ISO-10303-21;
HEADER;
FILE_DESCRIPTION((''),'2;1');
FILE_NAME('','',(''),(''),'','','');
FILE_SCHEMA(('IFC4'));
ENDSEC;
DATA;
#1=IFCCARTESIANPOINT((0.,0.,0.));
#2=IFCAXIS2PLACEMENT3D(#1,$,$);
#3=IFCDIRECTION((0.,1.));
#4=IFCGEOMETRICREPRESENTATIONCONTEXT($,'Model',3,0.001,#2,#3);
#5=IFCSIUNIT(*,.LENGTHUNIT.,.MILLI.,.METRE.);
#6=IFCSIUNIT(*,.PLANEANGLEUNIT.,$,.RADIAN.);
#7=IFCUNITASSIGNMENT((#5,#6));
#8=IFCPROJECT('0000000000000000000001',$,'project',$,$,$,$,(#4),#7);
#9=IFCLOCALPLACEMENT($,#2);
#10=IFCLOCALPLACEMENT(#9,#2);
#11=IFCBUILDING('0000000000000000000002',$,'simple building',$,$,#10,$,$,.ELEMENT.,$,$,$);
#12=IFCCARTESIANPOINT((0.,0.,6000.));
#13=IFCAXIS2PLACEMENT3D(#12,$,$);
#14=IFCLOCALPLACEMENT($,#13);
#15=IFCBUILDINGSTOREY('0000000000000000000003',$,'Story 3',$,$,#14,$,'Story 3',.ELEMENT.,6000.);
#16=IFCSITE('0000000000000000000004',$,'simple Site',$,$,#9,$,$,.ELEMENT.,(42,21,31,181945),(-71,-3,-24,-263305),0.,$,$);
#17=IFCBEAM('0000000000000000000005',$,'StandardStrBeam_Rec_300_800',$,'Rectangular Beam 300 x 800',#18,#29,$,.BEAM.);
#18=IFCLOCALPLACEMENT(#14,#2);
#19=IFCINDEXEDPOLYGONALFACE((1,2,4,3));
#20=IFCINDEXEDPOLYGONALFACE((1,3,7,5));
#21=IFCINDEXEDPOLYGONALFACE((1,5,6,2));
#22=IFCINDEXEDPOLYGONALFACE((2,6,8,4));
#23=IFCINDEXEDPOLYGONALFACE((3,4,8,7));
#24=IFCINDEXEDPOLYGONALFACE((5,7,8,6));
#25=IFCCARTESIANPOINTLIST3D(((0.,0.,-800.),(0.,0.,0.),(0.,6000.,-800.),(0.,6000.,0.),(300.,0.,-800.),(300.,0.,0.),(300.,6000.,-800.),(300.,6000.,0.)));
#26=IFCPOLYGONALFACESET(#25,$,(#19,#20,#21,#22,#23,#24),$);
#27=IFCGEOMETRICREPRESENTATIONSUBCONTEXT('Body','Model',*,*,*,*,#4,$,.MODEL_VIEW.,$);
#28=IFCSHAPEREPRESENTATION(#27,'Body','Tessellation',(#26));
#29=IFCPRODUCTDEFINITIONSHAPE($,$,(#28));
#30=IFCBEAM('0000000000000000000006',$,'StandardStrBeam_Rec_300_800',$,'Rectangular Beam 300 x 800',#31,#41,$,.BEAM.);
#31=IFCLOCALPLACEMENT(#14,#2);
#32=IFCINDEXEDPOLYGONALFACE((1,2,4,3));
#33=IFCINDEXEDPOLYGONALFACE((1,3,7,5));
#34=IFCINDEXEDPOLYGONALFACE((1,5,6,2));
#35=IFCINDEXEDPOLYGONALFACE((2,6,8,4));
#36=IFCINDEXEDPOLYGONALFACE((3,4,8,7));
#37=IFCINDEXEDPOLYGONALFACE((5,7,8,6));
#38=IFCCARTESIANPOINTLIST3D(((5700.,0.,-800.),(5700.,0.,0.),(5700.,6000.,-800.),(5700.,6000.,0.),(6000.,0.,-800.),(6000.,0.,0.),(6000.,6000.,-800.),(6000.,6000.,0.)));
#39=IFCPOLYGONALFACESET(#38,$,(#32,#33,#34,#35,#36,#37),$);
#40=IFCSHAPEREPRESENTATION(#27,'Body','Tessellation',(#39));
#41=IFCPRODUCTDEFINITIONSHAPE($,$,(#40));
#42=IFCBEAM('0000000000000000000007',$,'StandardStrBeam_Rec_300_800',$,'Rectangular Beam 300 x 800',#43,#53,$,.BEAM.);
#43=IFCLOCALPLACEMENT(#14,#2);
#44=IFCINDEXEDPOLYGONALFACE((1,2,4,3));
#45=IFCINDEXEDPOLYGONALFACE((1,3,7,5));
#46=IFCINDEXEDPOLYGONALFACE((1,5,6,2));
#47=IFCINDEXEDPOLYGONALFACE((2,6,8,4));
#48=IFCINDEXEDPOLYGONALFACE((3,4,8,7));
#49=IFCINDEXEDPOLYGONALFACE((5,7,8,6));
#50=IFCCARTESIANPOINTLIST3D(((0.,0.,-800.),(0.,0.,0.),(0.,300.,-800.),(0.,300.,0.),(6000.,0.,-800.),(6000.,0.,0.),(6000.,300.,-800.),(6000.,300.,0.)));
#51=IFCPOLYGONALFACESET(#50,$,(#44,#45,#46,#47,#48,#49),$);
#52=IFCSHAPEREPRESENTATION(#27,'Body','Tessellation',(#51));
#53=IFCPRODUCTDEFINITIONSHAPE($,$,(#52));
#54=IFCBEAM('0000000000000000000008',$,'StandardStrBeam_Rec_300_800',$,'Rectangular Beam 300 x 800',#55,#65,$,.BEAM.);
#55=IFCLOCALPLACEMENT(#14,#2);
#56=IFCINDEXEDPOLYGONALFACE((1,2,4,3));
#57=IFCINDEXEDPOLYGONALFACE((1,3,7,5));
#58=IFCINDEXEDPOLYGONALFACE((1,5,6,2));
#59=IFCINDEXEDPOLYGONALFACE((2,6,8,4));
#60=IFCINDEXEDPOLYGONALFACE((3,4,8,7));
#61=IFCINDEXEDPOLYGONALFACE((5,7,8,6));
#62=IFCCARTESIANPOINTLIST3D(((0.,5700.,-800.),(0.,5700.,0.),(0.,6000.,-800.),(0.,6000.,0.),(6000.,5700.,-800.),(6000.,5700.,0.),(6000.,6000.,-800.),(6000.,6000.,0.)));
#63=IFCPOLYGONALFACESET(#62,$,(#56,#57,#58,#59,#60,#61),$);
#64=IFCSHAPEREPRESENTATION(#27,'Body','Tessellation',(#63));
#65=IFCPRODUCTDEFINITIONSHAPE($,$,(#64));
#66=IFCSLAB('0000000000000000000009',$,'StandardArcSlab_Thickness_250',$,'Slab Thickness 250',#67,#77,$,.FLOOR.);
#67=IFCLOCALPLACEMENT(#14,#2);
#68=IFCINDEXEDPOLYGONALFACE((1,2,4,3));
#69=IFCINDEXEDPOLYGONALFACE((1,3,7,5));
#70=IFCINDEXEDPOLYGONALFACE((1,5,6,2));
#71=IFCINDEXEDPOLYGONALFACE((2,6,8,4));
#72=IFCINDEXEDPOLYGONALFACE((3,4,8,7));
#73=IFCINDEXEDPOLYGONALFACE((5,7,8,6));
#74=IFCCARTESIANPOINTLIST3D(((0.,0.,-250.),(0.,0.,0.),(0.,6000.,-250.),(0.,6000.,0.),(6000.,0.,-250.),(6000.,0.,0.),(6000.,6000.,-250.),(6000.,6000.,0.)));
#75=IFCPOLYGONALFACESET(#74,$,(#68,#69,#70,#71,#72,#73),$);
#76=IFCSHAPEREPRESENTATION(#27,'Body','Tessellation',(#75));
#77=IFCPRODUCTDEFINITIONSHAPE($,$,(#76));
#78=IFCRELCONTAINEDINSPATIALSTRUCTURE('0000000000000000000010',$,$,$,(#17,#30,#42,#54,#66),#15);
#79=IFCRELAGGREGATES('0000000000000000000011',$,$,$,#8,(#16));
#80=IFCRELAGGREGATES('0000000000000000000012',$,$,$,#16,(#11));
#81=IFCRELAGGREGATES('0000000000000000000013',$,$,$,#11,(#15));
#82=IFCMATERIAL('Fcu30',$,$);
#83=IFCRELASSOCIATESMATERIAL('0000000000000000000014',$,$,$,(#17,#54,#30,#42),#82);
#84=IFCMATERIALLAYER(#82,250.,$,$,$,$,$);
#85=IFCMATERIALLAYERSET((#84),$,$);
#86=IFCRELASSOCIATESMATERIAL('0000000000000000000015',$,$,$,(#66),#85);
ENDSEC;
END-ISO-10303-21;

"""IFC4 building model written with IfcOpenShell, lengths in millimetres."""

from ifc_helpers import new_model, si_unit, direction, frame, origin, origin_with_axes, origin_2d_with_axis, place, context, subcontext, project, spatial, polyline, rectangle, outline, extrude, material, layer, layer_set, layer_usage, material_profile, profile_set, profile_usage, element, save


model = new_model("IFC4")

# Units and contexts
model_context = context("Model", 3, precision=0.001, world=origin(), true_north=direction((0.0, 1.0)))
body_context = subcontext(model_context, "Body", "Model", "MODEL_VIEW")
ifc_project = project(units=[si_unit("LENGTHUNIT", "METRE", prefix="MILLI"), si_unit("PLANEANGLEUNIT", "RADIAN")], contexts=[model_context])

# Site, building, storey
site_placement = place(None, origin())
site = spatial("IfcSite", under=ifc_project, at=site_placement, Name="simple Site", CompositionType="ELEMENT", RefLatitude=(42, 21, 31, 181945), RefLongitude=(-71, -3, -24, -263305), RefElevation=0.0)
building_placement = place(site_placement, origin())
building = spatial("IfcBuilding", under=site, at=building_placement, Name="simple building", CompositionType="ELEMENT")
storey_placement = place(None, frame((0.0, 0.0, 6000.0)))
storey = spatial("IfcBuildingStorey", under=building, at=storey_placement, Name="Story 3", LongName="Story 3", CompositionType="ELEMENT", Elevation=6000.0)

# Beams
ifc_material = material(Name="Fcu30")
ifc_material_profile = material_profile(ifc_material, rectangle(XDim=300.0, YDim=800.0, at=origin_2d_with_axis()))
ifc_profile_set = profile_set([ifc_material_profile])
ifc_profile_usage_1 = profile_usage(ifc_profile_set, cardinal=7)
beam_1_placement = place(None, frame((150.0, 0.0, 5600.0), z_axis=(0.0, 1.0, 0.0), x_axis=(1.0, 0.0, 0.0)))
element("IfcBeam", 1, at=beam_1_placement, inside=storey, material=ifc_profile_usage_1, Name="StandardStrBeam_Rec_300_800", ObjectType="Rectangular Beam 300 x 800", PredefinedType="BEAM", context=body_context, shape_type="SweptSolid", body=[
    extrude(rectangle(XDim=300.0, YDim=800.0, at=origin_2d_with_axis()), origin_with_axes(), (0.0, 0.0, 1.0), 6000.0),
])
ifc_profile_usage_2 = profile_usage(ifc_profile_set, cardinal=9)
for number, where, z_axis, x_axis, name in (
    (2, (5850.0, 0.0, 5600.0), (0.0, 1.0, 0.0), (1.0, 0.0, 0.0), "StandardStrBeam_Rec_300_800"),
    (3, (0.0, 150.0, 5600.0), (1.0, 0.0, 0.0), (0.0, -1.0, 0.0), "StandardStrBeam_Rec_300_800"),
):
    element("IfcBeam", number, at=place(None, frame(where, z_axis=z_axis, x_axis=x_axis)), inside=storey, material=ifc_profile_usage_2, Name=name, ObjectType="Rectangular Beam 300 x 800", PredefinedType="BEAM", context=body_context, shape_type="SweptSolid", body=[
        extrude(rectangle(XDim=300.0, YDim=800.0, at=origin_2d_with_axis()), origin_with_axes(), (0.0, 0.0, 1.0), 6000.0),
    ])
beam_2_placement = place(None, frame((0.0, 5850.0, 5600.0), z_axis=(1.0, 0.0, 0.0), x_axis=(0.0, -1.0, 0.0)))
element("IfcBeam", 4, at=beam_2_placement, inside=storey, material=ifc_profile_usage_1, Name="StandardStrBeam_Rec_300_800", ObjectType="Rectangular Beam 300 x 800", PredefinedType="BEAM", context=body_context, shape_type="SweptSolid", body=[
    extrude(rectangle(XDim=300.0, YDim=800.0, at=origin_2d_with_axis()), origin_with_axes(), (0.0, 0.0, 1.0), 6000.0),
])

# Slab
ifc_layer = layer(ifc_material, 250.0)
ifc_layer_set = layer_set([ifc_layer])
ifc_layer_usage = layer_usage(ifc_layer_set, "AXIS3", "POSITIVE", -250.0)
slab_placement = place(None, frame((0.0, 0.0, 5750.0), z_axis=(0.0, 0.0, 1.0), x_axis=(1.0, 0.0, 0.0)))
element("IfcSlab", 5, at=slab_placement, inside=storey, material=ifc_layer_usage, Name="StandardArcSlab_Thickness_250", ObjectType="Slab Thickness 250", PredefinedType="FLOOR", context=body_context, shape_type="SweptSolid", body=[
    extrude(outline(polyline([(0.0, 0.0), (6000.0, 0.0), (6000.0, 6000.0), (0.0, 6000.0), (0.0, 0.0)])), origin_with_axes(), (0.0, 0.0, 1.0), 250.0),
])

save(model, "model.ifc")
